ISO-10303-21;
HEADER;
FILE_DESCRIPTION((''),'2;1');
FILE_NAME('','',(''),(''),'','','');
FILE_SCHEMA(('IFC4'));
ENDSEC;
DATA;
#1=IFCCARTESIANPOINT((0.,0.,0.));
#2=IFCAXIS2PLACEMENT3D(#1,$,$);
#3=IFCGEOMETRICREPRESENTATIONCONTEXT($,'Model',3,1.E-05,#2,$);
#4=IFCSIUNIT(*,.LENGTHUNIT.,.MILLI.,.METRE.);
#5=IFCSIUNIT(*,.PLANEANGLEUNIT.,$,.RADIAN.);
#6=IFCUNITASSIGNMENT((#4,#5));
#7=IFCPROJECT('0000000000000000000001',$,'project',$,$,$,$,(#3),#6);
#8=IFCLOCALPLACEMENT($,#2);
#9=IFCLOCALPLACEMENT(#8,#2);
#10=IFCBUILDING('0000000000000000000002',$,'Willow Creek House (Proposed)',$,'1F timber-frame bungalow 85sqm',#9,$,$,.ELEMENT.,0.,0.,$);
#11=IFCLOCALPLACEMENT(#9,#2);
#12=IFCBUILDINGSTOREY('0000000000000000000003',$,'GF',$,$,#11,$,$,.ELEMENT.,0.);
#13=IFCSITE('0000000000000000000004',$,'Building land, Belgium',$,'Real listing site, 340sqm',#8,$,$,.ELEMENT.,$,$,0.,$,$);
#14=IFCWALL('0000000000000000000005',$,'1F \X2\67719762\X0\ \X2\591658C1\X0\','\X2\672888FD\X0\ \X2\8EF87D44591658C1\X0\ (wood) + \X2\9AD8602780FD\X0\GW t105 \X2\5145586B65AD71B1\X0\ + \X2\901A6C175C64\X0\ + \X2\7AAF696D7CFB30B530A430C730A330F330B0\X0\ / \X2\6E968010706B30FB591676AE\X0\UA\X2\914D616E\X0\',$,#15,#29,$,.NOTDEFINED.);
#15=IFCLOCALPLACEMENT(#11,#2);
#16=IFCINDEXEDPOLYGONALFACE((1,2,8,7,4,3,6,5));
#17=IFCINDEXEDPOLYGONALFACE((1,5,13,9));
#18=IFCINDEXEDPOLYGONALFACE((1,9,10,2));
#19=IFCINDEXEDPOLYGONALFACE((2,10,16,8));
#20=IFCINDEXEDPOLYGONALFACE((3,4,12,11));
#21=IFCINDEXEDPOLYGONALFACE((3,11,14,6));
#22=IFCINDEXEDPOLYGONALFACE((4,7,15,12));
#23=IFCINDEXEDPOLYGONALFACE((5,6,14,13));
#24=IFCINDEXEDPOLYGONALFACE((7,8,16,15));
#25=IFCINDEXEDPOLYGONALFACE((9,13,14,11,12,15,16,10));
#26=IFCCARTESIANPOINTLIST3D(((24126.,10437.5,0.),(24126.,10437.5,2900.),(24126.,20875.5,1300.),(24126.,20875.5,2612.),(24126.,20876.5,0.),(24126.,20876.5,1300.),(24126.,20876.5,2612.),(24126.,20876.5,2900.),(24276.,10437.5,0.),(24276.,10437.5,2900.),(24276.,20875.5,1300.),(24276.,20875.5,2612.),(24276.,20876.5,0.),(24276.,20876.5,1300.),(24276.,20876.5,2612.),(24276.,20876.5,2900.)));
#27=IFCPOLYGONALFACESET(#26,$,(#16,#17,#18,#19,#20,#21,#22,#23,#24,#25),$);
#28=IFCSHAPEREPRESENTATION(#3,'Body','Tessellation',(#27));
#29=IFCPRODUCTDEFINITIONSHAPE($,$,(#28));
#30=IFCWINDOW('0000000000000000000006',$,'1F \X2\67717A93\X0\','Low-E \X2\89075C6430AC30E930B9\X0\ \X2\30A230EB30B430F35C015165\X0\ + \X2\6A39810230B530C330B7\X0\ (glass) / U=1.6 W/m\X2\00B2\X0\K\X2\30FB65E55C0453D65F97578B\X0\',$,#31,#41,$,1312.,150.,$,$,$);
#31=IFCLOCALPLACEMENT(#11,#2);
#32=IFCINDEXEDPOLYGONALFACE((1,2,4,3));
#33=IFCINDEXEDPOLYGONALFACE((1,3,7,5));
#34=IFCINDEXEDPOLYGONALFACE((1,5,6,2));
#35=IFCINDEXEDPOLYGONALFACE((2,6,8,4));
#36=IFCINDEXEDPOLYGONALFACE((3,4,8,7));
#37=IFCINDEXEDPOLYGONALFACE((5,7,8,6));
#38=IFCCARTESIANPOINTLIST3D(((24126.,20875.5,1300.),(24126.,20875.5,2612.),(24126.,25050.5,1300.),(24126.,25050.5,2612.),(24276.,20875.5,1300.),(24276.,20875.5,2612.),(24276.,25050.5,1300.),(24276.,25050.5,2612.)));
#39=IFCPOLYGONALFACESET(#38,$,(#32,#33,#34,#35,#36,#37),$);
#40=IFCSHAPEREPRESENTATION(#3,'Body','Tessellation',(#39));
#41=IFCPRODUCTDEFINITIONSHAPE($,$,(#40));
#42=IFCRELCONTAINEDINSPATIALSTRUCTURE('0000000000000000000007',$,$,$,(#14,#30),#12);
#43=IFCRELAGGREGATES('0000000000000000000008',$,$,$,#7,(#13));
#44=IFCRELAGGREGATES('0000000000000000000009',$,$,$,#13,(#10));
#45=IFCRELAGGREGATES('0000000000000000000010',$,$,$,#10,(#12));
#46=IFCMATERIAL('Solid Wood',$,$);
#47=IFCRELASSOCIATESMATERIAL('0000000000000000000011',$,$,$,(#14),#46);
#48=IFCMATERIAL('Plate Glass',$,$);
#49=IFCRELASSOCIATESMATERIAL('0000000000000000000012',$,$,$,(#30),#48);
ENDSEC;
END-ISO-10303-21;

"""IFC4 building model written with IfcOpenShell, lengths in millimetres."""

from ifc_helpers import new_model, si_unit, frame, frame_2d, origin, place, context, project, spatial, rectangle, extrude, material, element, fill, save


model = new_model("IFC4")

# Units and contexts
model_context = context("Model", 3, precision=1e-05, world=origin())
ifc_project = project(units=[si_unit("LENGTHUNIT", "METRE", prefix="MILLI"), si_unit("PLANEANGLEUNIT", "RADIAN")], contexts=[model_context])

# Site, building, storey
site_placement = place(None, origin())
site = spatial("IfcSite", under=ifc_project, at=site_placement, Name="Building land, Belgium", ObjectType="Real listing site, 340sqm", CompositionType="ELEMENT", RefElevation=0.0)
building_placement = place(site_placement, origin())
building = spatial("IfcBuilding", under=site, at=building_placement, Name="Willow Creek House (Proposed)", ObjectType="1F timber-frame bungalow 85sqm", CompositionType="ELEMENT", ElevationOfRefHeight=0.0, ElevationOfTerrain=0.0)
storey_placement = place(building_placement, origin())
storey = spatial("IfcBuildingStorey", under=building, at=storey_placement, Name="GF", CompositionType="ELEMENT", Elevation=0.0)

# Shared definitions
ifc_material_1 = material(Name="Solid Wood")

# Wall, opening, window
wall_1_placement = place(storey_placement, frame((12063.0, 5219.0, 0.0)))
wall_1 = element("IfcWall", 1, at=wall_1_placement, inside=storey, material=ifc_material_1, Name="1F 東面 外壁", Description="木製 軸組外壁 (wood) + 高性能GW t105 充填断熱 + 通気層 + 窯業系サイディング / 準耐火・外皮UA配慮", PredefinedType="NOTDEFINED", context=model_context, shape_type="SweptSolid", body=[
    extrude(rectangle(XDim=150.0, YDim=10439.0, at=frame_2d((75.0, 5219.0))), frame((12063.0, 5219.0, 0.0)), (0.0, 0.0, 1.0), 2900.0),
])
opening_placement = place(storey_placement, frame((12063.0, 10438.0, 650.0)))
opening = element("IfcOpeningElement", 2, at=opening_placement, cuts=wall_1, PredefinedType="NOTDEFINED", context=model_context, shape_type="SweptSolid", body=[
    extrude(rectangle(XDim=150.0, YDim=4175.0, at=frame_2d((75.0, 2087.0))), frame((12063.0, 10438.0, 650.0)), (0.0, 0.0, 1.0), 1312.0),
])
ifc_material_2 = material(Name="Plate Glass")
window_placement = place(storey_placement, frame((12063.0, 10438.0, 650.0)))
window = element("IfcWindow", 3, at=window_placement, inside=storey, material=ifc_material_2, Name="1F 東窓", Description="Low-E 複層ガラス アルゴン封入 + 樹脂サッシ (glass) / U=1.6 W/m²K・日射取得型", OverallHeight=1312.0, OverallWidth=150.0, context=model_context, shape_type="SweptSolid", body=[
    extrude(rectangle(XDim=150.0, YDim=4175.0, at=frame_2d((75.0, 2087.0))), frame((12063.0, 10438.0, 650.0)), (0.0, 0.0, 1.0), 1312.0),
])
fill(opening, window)

save(model, "model.ifc")
